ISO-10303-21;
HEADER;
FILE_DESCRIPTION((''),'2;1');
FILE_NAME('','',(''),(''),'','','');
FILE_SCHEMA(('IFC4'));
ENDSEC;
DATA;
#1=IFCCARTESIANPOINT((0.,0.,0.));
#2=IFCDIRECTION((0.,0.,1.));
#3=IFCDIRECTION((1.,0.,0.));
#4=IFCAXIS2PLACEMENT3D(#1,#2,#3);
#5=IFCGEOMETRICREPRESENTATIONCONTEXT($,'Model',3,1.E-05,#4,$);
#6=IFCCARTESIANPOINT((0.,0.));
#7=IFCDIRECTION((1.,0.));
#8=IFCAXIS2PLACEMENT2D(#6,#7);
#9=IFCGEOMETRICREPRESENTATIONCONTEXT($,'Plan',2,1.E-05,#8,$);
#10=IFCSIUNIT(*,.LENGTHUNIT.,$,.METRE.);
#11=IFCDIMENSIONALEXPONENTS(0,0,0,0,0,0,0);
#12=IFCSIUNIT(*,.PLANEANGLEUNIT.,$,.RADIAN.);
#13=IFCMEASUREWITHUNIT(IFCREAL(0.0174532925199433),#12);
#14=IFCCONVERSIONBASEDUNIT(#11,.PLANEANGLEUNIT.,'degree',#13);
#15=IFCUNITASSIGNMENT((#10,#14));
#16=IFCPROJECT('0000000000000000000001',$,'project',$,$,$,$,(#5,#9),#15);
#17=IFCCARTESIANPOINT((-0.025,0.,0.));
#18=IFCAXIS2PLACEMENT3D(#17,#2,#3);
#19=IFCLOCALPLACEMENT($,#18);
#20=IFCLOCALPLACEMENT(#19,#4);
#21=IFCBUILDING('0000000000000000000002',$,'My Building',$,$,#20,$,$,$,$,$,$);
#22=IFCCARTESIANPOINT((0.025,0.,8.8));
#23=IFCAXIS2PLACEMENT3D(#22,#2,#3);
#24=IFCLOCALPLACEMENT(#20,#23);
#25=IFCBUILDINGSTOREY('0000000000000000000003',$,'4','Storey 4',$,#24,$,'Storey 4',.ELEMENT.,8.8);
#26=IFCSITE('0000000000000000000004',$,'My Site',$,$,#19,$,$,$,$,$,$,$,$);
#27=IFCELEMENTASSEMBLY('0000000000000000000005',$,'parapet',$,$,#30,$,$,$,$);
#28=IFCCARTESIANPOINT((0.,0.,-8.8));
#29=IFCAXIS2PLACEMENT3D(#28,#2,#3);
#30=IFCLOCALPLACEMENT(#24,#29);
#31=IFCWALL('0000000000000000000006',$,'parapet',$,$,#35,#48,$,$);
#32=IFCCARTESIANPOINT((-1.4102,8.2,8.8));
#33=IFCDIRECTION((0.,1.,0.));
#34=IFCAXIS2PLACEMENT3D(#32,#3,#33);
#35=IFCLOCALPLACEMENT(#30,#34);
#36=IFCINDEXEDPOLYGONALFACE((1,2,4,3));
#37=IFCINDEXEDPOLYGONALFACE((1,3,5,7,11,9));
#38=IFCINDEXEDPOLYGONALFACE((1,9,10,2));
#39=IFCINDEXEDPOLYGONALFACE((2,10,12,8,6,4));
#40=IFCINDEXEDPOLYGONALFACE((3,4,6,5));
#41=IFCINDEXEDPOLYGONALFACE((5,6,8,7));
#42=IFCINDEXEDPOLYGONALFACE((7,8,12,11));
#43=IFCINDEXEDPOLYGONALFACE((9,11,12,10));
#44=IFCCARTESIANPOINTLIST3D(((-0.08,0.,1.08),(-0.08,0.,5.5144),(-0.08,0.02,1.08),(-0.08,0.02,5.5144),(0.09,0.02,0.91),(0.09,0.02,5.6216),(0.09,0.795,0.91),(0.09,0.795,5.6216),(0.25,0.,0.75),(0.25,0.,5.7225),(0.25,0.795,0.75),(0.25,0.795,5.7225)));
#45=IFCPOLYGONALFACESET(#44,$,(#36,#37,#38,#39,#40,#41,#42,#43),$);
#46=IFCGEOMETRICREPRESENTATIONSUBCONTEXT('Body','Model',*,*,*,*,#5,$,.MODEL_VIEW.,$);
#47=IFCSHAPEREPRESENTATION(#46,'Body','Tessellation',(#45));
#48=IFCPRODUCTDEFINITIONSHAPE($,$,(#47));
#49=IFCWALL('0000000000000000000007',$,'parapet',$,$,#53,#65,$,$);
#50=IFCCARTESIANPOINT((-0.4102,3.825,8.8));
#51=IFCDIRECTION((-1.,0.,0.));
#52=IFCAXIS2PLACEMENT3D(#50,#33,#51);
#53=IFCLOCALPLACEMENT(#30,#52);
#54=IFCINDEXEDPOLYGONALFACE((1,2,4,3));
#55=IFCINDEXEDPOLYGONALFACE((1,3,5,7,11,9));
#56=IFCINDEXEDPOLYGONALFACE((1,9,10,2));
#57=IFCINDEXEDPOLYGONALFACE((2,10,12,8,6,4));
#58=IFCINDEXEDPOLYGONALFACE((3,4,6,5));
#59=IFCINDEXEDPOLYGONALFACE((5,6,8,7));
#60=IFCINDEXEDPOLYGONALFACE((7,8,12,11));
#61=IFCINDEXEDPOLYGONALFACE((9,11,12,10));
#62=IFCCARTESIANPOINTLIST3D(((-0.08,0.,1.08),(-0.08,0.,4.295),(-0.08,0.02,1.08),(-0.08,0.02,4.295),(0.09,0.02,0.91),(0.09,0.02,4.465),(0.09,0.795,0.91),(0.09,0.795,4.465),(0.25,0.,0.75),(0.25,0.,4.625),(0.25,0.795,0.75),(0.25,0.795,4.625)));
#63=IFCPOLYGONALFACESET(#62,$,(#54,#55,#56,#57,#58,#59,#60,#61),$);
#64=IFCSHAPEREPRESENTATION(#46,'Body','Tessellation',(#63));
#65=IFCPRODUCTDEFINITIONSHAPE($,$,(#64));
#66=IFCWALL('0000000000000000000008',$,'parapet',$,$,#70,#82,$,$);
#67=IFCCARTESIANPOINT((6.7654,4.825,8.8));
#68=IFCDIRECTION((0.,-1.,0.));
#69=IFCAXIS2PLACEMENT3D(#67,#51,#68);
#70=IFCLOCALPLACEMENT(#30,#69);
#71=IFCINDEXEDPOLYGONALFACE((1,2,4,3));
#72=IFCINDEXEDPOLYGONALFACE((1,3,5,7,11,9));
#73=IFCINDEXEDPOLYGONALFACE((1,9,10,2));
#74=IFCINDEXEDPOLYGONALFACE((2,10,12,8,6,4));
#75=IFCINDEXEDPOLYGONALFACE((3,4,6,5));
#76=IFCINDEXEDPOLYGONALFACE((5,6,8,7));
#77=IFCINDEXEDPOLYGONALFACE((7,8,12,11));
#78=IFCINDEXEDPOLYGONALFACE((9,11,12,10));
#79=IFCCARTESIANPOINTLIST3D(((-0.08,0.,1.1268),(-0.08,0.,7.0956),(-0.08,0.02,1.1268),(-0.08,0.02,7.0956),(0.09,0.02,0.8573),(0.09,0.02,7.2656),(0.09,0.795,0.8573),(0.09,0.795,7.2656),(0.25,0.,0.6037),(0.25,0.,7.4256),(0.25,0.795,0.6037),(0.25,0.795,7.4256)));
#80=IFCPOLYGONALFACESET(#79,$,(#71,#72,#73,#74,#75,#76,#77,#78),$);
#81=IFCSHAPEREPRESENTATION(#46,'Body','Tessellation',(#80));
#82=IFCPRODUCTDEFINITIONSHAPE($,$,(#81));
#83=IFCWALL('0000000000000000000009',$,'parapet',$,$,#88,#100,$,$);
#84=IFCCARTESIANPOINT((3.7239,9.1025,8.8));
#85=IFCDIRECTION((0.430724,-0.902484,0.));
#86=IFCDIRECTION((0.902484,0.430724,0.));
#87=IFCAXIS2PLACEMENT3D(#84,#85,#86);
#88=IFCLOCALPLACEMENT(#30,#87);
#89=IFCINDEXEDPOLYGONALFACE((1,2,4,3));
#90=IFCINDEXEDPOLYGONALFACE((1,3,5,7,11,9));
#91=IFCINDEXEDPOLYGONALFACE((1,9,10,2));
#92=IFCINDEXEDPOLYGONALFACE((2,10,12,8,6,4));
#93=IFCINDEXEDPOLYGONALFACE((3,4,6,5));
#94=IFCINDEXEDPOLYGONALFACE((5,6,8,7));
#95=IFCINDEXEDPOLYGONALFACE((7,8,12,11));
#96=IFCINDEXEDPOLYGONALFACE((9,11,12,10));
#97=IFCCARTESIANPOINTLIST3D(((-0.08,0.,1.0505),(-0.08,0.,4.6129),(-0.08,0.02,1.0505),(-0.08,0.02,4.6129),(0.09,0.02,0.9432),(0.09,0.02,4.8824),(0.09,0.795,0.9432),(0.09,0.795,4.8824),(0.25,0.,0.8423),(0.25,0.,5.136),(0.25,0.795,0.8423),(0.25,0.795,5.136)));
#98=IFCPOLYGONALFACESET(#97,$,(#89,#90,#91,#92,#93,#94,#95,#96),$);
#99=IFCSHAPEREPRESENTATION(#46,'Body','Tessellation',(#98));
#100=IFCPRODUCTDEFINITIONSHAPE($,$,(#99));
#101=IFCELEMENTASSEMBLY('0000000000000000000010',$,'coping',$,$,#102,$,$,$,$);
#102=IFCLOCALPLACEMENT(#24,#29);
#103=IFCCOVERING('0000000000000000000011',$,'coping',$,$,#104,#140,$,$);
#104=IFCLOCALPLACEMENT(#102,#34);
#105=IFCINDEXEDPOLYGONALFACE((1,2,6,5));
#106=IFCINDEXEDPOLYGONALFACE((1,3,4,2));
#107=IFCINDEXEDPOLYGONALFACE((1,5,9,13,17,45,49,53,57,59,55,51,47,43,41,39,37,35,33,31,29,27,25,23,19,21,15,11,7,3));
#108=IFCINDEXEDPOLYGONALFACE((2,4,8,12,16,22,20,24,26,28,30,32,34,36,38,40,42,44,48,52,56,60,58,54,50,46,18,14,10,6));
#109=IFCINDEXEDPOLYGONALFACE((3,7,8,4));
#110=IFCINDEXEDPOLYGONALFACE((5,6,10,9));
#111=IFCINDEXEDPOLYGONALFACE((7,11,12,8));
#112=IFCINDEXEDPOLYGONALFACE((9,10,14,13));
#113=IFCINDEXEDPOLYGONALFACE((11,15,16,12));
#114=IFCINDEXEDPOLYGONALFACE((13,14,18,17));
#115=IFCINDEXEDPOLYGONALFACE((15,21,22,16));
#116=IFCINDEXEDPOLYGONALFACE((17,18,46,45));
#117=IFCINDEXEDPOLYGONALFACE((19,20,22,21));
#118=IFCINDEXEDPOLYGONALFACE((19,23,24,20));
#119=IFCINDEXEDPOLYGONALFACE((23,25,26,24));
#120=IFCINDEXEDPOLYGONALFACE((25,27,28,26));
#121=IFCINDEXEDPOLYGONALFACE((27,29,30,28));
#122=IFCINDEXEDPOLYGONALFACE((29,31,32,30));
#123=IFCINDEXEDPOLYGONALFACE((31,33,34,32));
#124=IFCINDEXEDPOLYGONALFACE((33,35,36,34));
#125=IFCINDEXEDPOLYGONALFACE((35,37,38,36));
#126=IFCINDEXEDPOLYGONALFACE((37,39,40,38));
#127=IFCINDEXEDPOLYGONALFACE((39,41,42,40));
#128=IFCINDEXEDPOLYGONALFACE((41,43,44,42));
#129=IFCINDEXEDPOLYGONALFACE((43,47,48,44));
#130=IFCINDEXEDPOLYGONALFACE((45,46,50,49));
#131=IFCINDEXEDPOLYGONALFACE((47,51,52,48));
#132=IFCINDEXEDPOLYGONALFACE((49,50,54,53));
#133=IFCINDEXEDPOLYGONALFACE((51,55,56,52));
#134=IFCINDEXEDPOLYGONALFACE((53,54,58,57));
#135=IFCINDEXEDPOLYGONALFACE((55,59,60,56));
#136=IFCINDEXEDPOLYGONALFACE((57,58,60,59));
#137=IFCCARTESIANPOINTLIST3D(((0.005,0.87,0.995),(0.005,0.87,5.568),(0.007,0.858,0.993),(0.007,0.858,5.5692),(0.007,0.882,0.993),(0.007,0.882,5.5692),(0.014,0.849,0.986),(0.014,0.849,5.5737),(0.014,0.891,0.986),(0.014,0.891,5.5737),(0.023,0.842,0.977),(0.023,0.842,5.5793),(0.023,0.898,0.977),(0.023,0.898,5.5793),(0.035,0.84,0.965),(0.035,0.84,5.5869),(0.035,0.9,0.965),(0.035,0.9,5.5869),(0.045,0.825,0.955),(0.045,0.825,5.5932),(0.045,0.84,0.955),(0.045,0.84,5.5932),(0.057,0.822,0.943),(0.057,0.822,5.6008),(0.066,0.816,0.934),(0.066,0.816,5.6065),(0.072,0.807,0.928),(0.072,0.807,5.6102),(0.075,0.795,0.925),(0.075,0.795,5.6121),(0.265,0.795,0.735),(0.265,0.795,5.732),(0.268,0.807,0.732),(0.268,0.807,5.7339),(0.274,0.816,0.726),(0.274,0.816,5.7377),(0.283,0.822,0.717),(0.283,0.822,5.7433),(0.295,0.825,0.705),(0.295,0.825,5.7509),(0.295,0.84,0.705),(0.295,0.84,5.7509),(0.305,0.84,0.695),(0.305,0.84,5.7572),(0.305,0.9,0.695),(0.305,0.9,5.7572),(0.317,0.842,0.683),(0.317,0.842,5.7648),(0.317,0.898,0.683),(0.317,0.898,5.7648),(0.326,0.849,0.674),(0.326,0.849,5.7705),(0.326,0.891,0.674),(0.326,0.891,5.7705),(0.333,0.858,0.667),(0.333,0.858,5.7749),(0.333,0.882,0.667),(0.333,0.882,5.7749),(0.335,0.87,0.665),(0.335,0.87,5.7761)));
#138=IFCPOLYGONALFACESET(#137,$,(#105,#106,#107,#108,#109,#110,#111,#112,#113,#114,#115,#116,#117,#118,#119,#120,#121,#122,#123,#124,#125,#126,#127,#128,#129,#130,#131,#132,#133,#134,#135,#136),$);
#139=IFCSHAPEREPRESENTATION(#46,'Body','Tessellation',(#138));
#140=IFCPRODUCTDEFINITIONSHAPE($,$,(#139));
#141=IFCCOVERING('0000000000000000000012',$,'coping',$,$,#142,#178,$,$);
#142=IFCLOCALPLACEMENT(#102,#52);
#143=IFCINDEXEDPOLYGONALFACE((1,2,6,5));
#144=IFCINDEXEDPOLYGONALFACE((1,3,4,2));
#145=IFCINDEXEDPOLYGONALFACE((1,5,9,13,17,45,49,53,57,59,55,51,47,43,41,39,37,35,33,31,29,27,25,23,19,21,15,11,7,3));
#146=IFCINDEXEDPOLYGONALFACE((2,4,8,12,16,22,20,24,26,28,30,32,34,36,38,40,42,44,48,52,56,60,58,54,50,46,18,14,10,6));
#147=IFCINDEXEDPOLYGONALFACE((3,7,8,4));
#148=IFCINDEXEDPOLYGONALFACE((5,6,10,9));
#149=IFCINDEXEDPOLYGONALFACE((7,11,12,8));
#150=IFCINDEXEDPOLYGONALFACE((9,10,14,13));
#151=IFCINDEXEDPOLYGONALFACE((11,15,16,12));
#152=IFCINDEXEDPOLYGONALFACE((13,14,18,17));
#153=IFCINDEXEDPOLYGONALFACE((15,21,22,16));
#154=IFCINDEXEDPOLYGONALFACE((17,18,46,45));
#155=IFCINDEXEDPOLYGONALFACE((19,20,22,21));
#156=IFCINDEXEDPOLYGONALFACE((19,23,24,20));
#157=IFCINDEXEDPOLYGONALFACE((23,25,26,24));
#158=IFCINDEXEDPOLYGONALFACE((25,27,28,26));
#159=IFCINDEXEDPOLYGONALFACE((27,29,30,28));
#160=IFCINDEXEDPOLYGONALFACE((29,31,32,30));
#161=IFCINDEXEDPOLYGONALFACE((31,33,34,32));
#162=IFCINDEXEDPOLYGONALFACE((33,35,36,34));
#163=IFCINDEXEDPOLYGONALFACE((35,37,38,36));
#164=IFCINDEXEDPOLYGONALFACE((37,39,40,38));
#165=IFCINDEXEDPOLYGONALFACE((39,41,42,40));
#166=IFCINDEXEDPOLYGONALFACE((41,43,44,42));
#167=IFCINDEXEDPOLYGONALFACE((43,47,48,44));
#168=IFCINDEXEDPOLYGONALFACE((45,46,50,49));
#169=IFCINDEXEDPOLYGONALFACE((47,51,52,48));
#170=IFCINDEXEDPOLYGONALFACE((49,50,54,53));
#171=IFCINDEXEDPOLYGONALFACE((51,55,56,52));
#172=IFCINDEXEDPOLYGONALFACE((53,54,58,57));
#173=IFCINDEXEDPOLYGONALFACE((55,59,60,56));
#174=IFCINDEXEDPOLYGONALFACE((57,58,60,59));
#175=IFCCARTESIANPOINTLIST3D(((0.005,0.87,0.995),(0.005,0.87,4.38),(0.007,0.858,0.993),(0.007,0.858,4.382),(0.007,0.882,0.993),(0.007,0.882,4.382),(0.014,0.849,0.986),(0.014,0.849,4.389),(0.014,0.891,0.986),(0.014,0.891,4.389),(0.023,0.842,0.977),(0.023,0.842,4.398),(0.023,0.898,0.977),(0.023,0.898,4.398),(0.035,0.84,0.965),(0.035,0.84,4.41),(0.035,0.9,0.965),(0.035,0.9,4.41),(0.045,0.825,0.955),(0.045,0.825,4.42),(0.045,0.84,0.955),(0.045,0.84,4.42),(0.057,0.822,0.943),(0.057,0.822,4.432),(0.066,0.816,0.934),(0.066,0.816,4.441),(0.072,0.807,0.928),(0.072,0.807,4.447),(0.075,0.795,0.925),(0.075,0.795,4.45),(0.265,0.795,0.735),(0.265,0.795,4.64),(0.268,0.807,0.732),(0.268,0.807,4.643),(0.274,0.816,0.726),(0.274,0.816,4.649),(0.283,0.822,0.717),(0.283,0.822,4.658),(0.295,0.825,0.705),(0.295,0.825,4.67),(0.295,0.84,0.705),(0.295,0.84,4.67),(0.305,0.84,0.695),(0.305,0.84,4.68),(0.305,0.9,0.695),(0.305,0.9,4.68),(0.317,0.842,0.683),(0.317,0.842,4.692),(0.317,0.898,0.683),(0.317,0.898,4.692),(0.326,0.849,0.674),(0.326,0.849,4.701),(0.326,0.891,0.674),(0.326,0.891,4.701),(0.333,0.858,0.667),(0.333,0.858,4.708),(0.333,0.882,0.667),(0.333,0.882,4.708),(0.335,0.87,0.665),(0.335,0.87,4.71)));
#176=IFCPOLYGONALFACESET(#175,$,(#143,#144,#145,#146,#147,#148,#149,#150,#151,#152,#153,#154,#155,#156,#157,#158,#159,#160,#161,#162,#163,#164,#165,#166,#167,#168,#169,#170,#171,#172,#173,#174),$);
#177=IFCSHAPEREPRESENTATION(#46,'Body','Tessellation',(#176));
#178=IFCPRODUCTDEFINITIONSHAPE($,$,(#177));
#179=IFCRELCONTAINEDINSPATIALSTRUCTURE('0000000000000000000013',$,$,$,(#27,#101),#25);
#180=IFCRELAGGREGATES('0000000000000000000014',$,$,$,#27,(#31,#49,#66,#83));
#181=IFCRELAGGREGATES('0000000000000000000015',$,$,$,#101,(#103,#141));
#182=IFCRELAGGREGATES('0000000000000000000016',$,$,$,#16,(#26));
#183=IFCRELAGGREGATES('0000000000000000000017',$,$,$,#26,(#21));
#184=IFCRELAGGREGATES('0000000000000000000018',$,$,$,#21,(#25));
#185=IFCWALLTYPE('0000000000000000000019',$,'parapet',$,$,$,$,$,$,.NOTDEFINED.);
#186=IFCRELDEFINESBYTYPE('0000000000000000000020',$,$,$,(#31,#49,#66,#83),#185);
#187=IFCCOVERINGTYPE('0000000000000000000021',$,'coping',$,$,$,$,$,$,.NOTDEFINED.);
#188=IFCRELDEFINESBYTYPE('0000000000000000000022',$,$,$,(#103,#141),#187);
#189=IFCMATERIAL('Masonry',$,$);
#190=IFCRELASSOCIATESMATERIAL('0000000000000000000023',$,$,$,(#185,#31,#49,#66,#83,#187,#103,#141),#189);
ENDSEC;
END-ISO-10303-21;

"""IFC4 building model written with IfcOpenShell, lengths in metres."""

from ifc_helpers import new_model, entity, si_unit, converted_unit, frame, origin_with_axes, origin_2d_with_axis, place, context, subcontext, project, spatial, polyline, outline, extrude, clip, halfspace, material, material_profile, profile_set, profile_usage, type_object, element, aggregate, save


model = new_model("IFC4")

# Units and contexts
model_context = context("Model", 3, precision=1e-05, world=origin_with_axes())
plan_context = context("Plan", 2, precision=1e-05, world=origin_2d_with_axis())
body_context = subcontext(model_context, "Body", "Model", "MODEL_VIEW")
ifc_project = project(units=[si_unit("LENGTHUNIT", "METRE"), converted_unit("PLANEANGLEUNIT", "degree", entity("IfcReal", 0.0174532925199433), si_unit("PLANEANGLEUNIT", "RADIAN"), dimensions=[0, 0, 0, 0, 0, 0, 0])], contexts=[model_context, plan_context])

# Site, building, storey
site_placement = place(None, frame((-0.025, 0.0, 0.0), z_axis=(0.0, 0.0, 1.0), x_axis=(1.0, 0.0, 0.0)))
site = spatial("IfcSite", under=ifc_project, at=site_placement, Name="My Site")
building_placement = place(site_placement, origin_with_axes())
building = spatial("IfcBuilding", under=site, at=building_placement, Name="My Building")
storey_placement = place(building_placement, frame((0.025, 0.0, 8.8), z_axis=(0.0, 0.0, 1.0), x_axis=(1.0, 0.0, 0.0)))
storey = spatial("IfcBuildingStorey", under=building, at=storey_placement, Name="4", Description="Storey 4", LongName="Storey 4", CompositionType="ELEMENT", Elevation=8.8)

# Element assembly, walls
assembly_1_placement = place(storey_placement, frame((0.0, 0.0, -8.8), z_axis=(0.0, 0.0, 1.0), x_axis=(1.0, 0.0, 0.0)))
assembly_1 = element("IfcElementAssembly", 1, at=assembly_1_placement, inside=storey, Name="parapet")
ifc_material_1 = material(Name="Masonry")
ifc_material_profile_1 = material_profile(ifc_material_1, outline(polyline([(0.25, 0.0), (0.25, 0.795), (0.09, 0.795), (0.09, 0.02), (-0.08, 0.02), (-0.08, 0.0), (0.25, 0.0)])))
ifc_profile_set_1 = profile_set([ifc_material_profile_1])
ifc_profile_usage_1 = profile_usage(ifc_profile_set_1)
wall_type = type_object("IfcWallType", Name="parapet", PredefinedType="NOTDEFINED", material=ifc_profile_set_1)
wall_1_placement = place(assembly_1_placement, frame((-1.4102, 8.2, 8.8), z_axis=(1.0, 0.0, 0.0), x_axis=(0.0, 1.0, 0.0)))
wall_1 = element("IfcWall", 2, at=wall_1_placement, type_object=wall_type, material=ifc_profile_usage_1, Name="parapet", context=body_context, shape_type="Clipping", body=[
    clip(clip(extrude(outline(polyline([(0.25, 0.0), (0.25, 0.795), (0.09, 0.795), (0.09, 0.02), (-0.08, 0.02), (-0.08, 0.0), (0.25, 0.0)])), origin_with_axes(), (0.0, 0.0, 1.0), 6.5648), halfspace(frame((0.0, -8.8, 1.0), z_axis=(-0.707107, 0.0, -0.707107), x_axis=(0.0, 1.0, 0.0)), False)), halfspace(frame((0.0, -8.8, 5.5648), z_axis=(-0.533515, 0.0, 0.845791), x_axis=(0.0, 1.0, 0.0)), False)),
])
ifc_profile_usage_2 = profile_usage(ifc_profile_set_1)
wall_2_placement = place(assembly_1_placement, frame((-0.4102, 3.825, 8.8), z_axis=(0.0, 1.0, 0.0), x_axis=(-1.0, 0.0, 0.0)))
wall_2 = element("IfcWall", 3, at=wall_2_placement, type_object=wall_type, material=ifc_profile_usage_2, Name="parapet", context=body_context, shape_type="Clipping", body=[
    clip(clip(extrude(outline(polyline([(0.25, 0.0), (0.25, 0.795), (0.09, 0.795), (0.09, 0.02), (-0.08, 0.02), (-0.08, 0.0), (0.25, 0.0)])), origin_with_axes(), (0.0, 0.0, 1.0), 5.375), halfspace(frame((0.0, -8.8, 1.0), z_axis=(-0.707107, 0.0, -0.707107), x_axis=(0.0, 1.0, 0.0)), False)), halfspace(frame((0.0, -8.8, 4.375), z_axis=(-0.707107, 0.0, 0.707107), x_axis=(0.0, 1.0, 0.0)), False)),
])
ifc_profile_usage_3 = profile_usage(ifc_profile_set_1)
wall_3_placement = place(assembly_1_placement, frame((6.7654, 4.825, 8.8), z_axis=(-1.0, 0.0, 0.0), x_axis=(0.0, -1.0, 0.0)))
wall_3 = element("IfcWall", 4, at=wall_3_placement, type_object=wall_type, material=ifc_profile_usage_3, Name="parapet", context=body_context, shape_type="Clipping", body=[
    clip(clip(extrude(outline(polyline([(0.25, 0.0), (0.25, 0.795), (0.09, 0.795), (0.09, 0.02), (-0.08, 0.02), (-0.08, 0.0), (0.25, 0.0)])), origin_with_axes(), (0.0, 0.0, 1.0), 8.1756), halfspace(frame((0.0, -8.8, 1.0), z_axis=(-0.845791, 0.0, -0.533515), x_axis=(0.0, 1.0, 0.0)), False)), halfspace(frame((0.0, -8.8, 7.1756), z_axis=(-0.707107, 0.0, 0.707107), x_axis=(0.0, 1.0, 0.0)), False)),
])
ifc_profile_usage_4 = profile_usage(ifc_profile_set_1)
wall_4_placement = place(assembly_1_placement, frame((3.7239, 9.1025, 8.8), z_axis=(0.430724, -0.902484, 0.0), x_axis=(0.902484, 0.430724, 0.0)))
wall_4 = element("IfcWall", 5, at=wall_4_placement, type_object=wall_type, material=ifc_profile_usage_4, Name="parapet", context=body_context, shape_type="Clipping", body=[
    clip(clip(extrude(outline(polyline([(0.25, 0.0), (0.25, 0.795), (0.09, 0.795), (0.09, 0.02), (-0.08, 0.02), (-0.08, 0.0), (0.25, 0.0)])), origin_with_axes(), (0.0, 0.0, 1.0), 5.7397), halfspace(frame((0.0, -8.8, 1.0), z_axis=(-0.533515, 0.0, -0.845791), x_axis=(0.0, 1.0, 0.0)), False)), halfspace(frame((0.0, -8.8, 4.7397), z_axis=(-0.845791, 0.0, 0.533515), x_axis=(0.0, 1.0, 0.0)), False)),
])
aggregate(assembly_1, [wall_1, wall_2, wall_3, wall_4])

# Element assembly, coverings
assembly_2_placement = place(storey_placement, frame((0.0, 0.0, -8.8), z_axis=(0.0, 0.0, 1.0), x_axis=(1.0, 0.0, 0.0)))
assembly_2 = element("IfcElementAssembly", 6, at=assembly_2_placement, inside=storey, Name="coping")
ifc_material_profile_2 = material_profile(ifc_material_1, outline(polyline([(0.265, 0.795), (0.268, 0.807), (0.274, 0.816), (0.283, 0.822), (0.295, 0.825), (0.295, 0.84), (0.305, 0.84), (0.317, 0.842), (0.326, 0.849), (0.333, 0.858), (0.335, 0.87), (0.333, 0.882), (0.326, 0.891), (0.317, 0.898), (0.305, 0.9), (0.035, 0.9), (0.023, 0.898), (0.014, 0.891), (0.007, 0.882), (0.005, 0.87), (0.007, 0.858), (0.014, 0.849), (0.023, 0.842), (0.035, 0.84), (0.045, 0.84), (0.045, 0.825), (0.057, 0.822), (0.066, 0.816), (0.072, 0.807), (0.075, 0.795), (0.265, 0.795)])))
ifc_profile_set_2 = profile_set([ifc_material_profile_2])
ifc_profile_usage_5 = profile_usage(ifc_profile_set_2)
covering_type_1 = type_object("IfcCoveringType", Name="coping", PredefinedType="NOTDEFINED", material=ifc_profile_set_2)
covering_1_placement = place(assembly_2_placement, frame((-1.4102, 8.2, 8.8), z_axis=(1.0, 0.0, 0.0), x_axis=(0.0, 1.0, 0.0)))
covering_1 = element("IfcCovering", 7, at=covering_1_placement, type_object=covering_type_1, material=ifc_profile_usage_5, Name="coping", context=body_context, shape_type="Clipping", body=[
    clip(clip(extrude(outline(polyline([(0.265, 0.795), (0.268, 0.807), (0.274, 0.816), (0.283, 0.822), (0.295, 0.825), (0.295, 0.84), (0.305, 0.84), (0.317, 0.842), (0.326, 0.849), (0.333, 0.858), (0.335, 0.87), (0.333, 0.882), (0.326, 0.891), (0.317, 0.898), (0.305, 0.9), (0.035, 0.9), (0.023, 0.898), (0.014, 0.891), (0.007, 0.882), (0.005, 0.87), (0.007, 0.858), (0.014, 0.849), (0.023, 0.842), (0.035, 0.84), (0.045, 0.84), (0.045, 0.825), (0.057, 0.822), (0.066, 0.816), (0.072, 0.807), (0.075, 0.795), (0.265, 0.795)])), origin_with_axes(), (0.0, 0.0, 1.0), 6.5648), halfspace(frame((0.0, -8.8, 1.0), z_axis=(-0.707107, 0.0, -0.707107), x_axis=(0.0, 1.0, 0.0)), False)), halfspace(frame((0.0, -8.8, 5.5648), z_axis=(-0.533515, 0.0, 0.845791), x_axis=(0.0, 1.0, 0.0)), False)),
])
ifc_profile_usage_6 = profile_usage(ifc_profile_set_2)
covering_2_placement = place(assembly_2_placement, frame((-0.4102, 3.825, 8.8), z_axis=(0.0, 1.0, 0.0), x_axis=(-1.0, 0.0, 0.0)))
covering_2 = element("IfcCovering", 8, at=covering_2_placement, type_object=covering_type_1, material=ifc_profile_usage_6, Name="coping", context=body_context, shape_type="Clipping", body=[
    clip(clip(extrude(outline(polyline([(0.265, 0.795), (0.268, 0.807), (0.274, 0.816), (0.283, 0.822), (0.295, 0.825), (0.295, 0.84), (0.305, 0.84), (0.317, 0.842), (0.326, 0.849), (0.333, 0.858), (0.335, 0.87), (0.333, 0.882), (0.326, 0.891), (0.317, 0.898), (0.305, 0.9), (0.035, 0.9), (0.023, 0.898), (0.014, 0.891), (0.007, 0.882), (0.005, 0.87), (0.007, 0.858), (0.014, 0.849), (0.023, 0.842), (0.035, 0.84), (0.045, 0.84), (0.045, 0.825), (0.057, 0.822), (0.066, 0.816), (0.072, 0.807), (0.075, 0.795), (0.265, 0.795)])), origin_with_axes(), (0.0, 0.0, 1.0), 5.375), halfspace(frame((0.0, -8.8, 1.0), z_axis=(-0.707107, 0.0, -0.707107), x_axis=(0.0, 1.0, 0.0)), False)), halfspace(frame((0.0, -8.8, 4.375), z_axis=(-0.707107, 0.0, 0.707107), x_axis=(0.0, 1.0, 0.0)), False)),
])
aggregate(assembly_2, [covering_1, covering_2])

save(model, "model.ifc")
